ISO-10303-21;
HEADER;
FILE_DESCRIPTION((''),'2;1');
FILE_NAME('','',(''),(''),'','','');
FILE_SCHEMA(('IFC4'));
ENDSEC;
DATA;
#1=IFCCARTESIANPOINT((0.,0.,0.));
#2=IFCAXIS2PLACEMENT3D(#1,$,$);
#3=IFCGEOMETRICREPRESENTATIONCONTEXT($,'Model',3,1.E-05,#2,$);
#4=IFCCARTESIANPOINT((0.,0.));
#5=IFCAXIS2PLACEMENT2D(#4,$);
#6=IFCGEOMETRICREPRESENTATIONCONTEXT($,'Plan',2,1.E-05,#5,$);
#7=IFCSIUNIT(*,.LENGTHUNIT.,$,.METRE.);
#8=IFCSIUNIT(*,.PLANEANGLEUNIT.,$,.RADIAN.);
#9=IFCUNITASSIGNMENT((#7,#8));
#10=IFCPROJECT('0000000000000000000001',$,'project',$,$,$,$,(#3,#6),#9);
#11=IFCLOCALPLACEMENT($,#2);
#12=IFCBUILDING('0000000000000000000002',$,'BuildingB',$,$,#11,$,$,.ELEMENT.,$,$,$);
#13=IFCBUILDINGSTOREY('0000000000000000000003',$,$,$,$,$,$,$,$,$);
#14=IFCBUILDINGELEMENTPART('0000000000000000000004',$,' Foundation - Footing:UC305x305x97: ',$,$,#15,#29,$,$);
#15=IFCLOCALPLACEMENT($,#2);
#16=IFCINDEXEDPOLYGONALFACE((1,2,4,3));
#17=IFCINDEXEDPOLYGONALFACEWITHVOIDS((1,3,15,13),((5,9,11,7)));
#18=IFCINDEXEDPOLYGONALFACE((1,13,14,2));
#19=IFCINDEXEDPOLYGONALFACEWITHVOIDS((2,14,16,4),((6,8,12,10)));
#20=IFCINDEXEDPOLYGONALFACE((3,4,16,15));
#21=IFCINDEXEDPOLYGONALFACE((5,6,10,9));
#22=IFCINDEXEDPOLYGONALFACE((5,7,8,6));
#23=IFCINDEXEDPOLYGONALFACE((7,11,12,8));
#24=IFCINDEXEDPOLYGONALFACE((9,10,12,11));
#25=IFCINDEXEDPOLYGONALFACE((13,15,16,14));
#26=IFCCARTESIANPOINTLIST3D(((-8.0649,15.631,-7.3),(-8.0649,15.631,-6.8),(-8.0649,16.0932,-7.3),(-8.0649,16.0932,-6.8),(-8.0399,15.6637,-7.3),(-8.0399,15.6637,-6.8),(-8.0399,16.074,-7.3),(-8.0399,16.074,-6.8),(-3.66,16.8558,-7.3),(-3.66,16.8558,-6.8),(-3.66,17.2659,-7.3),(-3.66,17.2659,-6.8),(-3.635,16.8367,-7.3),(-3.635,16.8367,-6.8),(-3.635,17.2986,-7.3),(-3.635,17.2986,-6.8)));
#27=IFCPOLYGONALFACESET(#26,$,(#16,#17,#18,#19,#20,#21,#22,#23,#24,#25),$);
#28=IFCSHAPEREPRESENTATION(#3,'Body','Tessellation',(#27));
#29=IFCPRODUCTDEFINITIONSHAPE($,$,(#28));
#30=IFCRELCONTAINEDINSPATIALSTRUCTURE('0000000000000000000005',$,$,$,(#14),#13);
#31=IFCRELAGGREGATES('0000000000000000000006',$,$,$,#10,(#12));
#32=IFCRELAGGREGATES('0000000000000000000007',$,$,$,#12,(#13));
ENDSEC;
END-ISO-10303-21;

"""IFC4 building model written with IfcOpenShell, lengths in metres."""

from ifc_helpers import new_model, si_unit, origin, origin_2d, place, context, project, spatial, polyline, outline, extrude, element, save


model = new_model("IFC4")

# Units and contexts
model_context = context("Model", 3, precision=1e-05, world=origin())
plan_context = context("Plan", 2, precision=1e-05, world=origin_2d())
ifc_project = project(units=[si_unit("LENGTHUNIT", "METRE"), si_unit("PLANEANGLEUNIT", "RADIAN")], contexts=[model_context, plan_context])

# Building, storey
building_placement = place(None, origin())
building = spatial("IfcBuilding", under=ifc_project, at=building_placement, Name="BuildingB", CompositionType="ELEMENT")
storey = spatial("IfcBuildingStorey", under=building)

# Building element part, opening
building_element_part_1 = element("IfcBuildingElementPart", 1, inside=storey, Name=" Foundation - Footing:UC305x305x97: ", context=model_context, shape_type="SweptSolid", body=[
    extrude(outline(polyline([(-8.0649, 15.631, -7.3), (-8.0649, 16.0932, -7.3), (-3.635, 17.2986, -7.3), (-3.635, 16.8367, -7.3), (-8.0649, 15.631, -7.3)])), None, (0.0, 0.0, 1.0), 0.5),
])
element("IfcOpeningElement", 2, inside=storey, cuts=building_element_part_1, context=model_context, shape_type="SweptSolid", body=[
    extrude(outline(polyline([(-8.0399, 15.6637, -7.3), (-8.0399, 16.074, -7.3), (-3.66, 17.2659, -7.3), (-3.66, 16.8558, -7.3), (-8.0399, 15.6637, -7.3)])), None, (0.0, 0.0, 1.0), 0.5),
])

save(model, "model.ifc")
